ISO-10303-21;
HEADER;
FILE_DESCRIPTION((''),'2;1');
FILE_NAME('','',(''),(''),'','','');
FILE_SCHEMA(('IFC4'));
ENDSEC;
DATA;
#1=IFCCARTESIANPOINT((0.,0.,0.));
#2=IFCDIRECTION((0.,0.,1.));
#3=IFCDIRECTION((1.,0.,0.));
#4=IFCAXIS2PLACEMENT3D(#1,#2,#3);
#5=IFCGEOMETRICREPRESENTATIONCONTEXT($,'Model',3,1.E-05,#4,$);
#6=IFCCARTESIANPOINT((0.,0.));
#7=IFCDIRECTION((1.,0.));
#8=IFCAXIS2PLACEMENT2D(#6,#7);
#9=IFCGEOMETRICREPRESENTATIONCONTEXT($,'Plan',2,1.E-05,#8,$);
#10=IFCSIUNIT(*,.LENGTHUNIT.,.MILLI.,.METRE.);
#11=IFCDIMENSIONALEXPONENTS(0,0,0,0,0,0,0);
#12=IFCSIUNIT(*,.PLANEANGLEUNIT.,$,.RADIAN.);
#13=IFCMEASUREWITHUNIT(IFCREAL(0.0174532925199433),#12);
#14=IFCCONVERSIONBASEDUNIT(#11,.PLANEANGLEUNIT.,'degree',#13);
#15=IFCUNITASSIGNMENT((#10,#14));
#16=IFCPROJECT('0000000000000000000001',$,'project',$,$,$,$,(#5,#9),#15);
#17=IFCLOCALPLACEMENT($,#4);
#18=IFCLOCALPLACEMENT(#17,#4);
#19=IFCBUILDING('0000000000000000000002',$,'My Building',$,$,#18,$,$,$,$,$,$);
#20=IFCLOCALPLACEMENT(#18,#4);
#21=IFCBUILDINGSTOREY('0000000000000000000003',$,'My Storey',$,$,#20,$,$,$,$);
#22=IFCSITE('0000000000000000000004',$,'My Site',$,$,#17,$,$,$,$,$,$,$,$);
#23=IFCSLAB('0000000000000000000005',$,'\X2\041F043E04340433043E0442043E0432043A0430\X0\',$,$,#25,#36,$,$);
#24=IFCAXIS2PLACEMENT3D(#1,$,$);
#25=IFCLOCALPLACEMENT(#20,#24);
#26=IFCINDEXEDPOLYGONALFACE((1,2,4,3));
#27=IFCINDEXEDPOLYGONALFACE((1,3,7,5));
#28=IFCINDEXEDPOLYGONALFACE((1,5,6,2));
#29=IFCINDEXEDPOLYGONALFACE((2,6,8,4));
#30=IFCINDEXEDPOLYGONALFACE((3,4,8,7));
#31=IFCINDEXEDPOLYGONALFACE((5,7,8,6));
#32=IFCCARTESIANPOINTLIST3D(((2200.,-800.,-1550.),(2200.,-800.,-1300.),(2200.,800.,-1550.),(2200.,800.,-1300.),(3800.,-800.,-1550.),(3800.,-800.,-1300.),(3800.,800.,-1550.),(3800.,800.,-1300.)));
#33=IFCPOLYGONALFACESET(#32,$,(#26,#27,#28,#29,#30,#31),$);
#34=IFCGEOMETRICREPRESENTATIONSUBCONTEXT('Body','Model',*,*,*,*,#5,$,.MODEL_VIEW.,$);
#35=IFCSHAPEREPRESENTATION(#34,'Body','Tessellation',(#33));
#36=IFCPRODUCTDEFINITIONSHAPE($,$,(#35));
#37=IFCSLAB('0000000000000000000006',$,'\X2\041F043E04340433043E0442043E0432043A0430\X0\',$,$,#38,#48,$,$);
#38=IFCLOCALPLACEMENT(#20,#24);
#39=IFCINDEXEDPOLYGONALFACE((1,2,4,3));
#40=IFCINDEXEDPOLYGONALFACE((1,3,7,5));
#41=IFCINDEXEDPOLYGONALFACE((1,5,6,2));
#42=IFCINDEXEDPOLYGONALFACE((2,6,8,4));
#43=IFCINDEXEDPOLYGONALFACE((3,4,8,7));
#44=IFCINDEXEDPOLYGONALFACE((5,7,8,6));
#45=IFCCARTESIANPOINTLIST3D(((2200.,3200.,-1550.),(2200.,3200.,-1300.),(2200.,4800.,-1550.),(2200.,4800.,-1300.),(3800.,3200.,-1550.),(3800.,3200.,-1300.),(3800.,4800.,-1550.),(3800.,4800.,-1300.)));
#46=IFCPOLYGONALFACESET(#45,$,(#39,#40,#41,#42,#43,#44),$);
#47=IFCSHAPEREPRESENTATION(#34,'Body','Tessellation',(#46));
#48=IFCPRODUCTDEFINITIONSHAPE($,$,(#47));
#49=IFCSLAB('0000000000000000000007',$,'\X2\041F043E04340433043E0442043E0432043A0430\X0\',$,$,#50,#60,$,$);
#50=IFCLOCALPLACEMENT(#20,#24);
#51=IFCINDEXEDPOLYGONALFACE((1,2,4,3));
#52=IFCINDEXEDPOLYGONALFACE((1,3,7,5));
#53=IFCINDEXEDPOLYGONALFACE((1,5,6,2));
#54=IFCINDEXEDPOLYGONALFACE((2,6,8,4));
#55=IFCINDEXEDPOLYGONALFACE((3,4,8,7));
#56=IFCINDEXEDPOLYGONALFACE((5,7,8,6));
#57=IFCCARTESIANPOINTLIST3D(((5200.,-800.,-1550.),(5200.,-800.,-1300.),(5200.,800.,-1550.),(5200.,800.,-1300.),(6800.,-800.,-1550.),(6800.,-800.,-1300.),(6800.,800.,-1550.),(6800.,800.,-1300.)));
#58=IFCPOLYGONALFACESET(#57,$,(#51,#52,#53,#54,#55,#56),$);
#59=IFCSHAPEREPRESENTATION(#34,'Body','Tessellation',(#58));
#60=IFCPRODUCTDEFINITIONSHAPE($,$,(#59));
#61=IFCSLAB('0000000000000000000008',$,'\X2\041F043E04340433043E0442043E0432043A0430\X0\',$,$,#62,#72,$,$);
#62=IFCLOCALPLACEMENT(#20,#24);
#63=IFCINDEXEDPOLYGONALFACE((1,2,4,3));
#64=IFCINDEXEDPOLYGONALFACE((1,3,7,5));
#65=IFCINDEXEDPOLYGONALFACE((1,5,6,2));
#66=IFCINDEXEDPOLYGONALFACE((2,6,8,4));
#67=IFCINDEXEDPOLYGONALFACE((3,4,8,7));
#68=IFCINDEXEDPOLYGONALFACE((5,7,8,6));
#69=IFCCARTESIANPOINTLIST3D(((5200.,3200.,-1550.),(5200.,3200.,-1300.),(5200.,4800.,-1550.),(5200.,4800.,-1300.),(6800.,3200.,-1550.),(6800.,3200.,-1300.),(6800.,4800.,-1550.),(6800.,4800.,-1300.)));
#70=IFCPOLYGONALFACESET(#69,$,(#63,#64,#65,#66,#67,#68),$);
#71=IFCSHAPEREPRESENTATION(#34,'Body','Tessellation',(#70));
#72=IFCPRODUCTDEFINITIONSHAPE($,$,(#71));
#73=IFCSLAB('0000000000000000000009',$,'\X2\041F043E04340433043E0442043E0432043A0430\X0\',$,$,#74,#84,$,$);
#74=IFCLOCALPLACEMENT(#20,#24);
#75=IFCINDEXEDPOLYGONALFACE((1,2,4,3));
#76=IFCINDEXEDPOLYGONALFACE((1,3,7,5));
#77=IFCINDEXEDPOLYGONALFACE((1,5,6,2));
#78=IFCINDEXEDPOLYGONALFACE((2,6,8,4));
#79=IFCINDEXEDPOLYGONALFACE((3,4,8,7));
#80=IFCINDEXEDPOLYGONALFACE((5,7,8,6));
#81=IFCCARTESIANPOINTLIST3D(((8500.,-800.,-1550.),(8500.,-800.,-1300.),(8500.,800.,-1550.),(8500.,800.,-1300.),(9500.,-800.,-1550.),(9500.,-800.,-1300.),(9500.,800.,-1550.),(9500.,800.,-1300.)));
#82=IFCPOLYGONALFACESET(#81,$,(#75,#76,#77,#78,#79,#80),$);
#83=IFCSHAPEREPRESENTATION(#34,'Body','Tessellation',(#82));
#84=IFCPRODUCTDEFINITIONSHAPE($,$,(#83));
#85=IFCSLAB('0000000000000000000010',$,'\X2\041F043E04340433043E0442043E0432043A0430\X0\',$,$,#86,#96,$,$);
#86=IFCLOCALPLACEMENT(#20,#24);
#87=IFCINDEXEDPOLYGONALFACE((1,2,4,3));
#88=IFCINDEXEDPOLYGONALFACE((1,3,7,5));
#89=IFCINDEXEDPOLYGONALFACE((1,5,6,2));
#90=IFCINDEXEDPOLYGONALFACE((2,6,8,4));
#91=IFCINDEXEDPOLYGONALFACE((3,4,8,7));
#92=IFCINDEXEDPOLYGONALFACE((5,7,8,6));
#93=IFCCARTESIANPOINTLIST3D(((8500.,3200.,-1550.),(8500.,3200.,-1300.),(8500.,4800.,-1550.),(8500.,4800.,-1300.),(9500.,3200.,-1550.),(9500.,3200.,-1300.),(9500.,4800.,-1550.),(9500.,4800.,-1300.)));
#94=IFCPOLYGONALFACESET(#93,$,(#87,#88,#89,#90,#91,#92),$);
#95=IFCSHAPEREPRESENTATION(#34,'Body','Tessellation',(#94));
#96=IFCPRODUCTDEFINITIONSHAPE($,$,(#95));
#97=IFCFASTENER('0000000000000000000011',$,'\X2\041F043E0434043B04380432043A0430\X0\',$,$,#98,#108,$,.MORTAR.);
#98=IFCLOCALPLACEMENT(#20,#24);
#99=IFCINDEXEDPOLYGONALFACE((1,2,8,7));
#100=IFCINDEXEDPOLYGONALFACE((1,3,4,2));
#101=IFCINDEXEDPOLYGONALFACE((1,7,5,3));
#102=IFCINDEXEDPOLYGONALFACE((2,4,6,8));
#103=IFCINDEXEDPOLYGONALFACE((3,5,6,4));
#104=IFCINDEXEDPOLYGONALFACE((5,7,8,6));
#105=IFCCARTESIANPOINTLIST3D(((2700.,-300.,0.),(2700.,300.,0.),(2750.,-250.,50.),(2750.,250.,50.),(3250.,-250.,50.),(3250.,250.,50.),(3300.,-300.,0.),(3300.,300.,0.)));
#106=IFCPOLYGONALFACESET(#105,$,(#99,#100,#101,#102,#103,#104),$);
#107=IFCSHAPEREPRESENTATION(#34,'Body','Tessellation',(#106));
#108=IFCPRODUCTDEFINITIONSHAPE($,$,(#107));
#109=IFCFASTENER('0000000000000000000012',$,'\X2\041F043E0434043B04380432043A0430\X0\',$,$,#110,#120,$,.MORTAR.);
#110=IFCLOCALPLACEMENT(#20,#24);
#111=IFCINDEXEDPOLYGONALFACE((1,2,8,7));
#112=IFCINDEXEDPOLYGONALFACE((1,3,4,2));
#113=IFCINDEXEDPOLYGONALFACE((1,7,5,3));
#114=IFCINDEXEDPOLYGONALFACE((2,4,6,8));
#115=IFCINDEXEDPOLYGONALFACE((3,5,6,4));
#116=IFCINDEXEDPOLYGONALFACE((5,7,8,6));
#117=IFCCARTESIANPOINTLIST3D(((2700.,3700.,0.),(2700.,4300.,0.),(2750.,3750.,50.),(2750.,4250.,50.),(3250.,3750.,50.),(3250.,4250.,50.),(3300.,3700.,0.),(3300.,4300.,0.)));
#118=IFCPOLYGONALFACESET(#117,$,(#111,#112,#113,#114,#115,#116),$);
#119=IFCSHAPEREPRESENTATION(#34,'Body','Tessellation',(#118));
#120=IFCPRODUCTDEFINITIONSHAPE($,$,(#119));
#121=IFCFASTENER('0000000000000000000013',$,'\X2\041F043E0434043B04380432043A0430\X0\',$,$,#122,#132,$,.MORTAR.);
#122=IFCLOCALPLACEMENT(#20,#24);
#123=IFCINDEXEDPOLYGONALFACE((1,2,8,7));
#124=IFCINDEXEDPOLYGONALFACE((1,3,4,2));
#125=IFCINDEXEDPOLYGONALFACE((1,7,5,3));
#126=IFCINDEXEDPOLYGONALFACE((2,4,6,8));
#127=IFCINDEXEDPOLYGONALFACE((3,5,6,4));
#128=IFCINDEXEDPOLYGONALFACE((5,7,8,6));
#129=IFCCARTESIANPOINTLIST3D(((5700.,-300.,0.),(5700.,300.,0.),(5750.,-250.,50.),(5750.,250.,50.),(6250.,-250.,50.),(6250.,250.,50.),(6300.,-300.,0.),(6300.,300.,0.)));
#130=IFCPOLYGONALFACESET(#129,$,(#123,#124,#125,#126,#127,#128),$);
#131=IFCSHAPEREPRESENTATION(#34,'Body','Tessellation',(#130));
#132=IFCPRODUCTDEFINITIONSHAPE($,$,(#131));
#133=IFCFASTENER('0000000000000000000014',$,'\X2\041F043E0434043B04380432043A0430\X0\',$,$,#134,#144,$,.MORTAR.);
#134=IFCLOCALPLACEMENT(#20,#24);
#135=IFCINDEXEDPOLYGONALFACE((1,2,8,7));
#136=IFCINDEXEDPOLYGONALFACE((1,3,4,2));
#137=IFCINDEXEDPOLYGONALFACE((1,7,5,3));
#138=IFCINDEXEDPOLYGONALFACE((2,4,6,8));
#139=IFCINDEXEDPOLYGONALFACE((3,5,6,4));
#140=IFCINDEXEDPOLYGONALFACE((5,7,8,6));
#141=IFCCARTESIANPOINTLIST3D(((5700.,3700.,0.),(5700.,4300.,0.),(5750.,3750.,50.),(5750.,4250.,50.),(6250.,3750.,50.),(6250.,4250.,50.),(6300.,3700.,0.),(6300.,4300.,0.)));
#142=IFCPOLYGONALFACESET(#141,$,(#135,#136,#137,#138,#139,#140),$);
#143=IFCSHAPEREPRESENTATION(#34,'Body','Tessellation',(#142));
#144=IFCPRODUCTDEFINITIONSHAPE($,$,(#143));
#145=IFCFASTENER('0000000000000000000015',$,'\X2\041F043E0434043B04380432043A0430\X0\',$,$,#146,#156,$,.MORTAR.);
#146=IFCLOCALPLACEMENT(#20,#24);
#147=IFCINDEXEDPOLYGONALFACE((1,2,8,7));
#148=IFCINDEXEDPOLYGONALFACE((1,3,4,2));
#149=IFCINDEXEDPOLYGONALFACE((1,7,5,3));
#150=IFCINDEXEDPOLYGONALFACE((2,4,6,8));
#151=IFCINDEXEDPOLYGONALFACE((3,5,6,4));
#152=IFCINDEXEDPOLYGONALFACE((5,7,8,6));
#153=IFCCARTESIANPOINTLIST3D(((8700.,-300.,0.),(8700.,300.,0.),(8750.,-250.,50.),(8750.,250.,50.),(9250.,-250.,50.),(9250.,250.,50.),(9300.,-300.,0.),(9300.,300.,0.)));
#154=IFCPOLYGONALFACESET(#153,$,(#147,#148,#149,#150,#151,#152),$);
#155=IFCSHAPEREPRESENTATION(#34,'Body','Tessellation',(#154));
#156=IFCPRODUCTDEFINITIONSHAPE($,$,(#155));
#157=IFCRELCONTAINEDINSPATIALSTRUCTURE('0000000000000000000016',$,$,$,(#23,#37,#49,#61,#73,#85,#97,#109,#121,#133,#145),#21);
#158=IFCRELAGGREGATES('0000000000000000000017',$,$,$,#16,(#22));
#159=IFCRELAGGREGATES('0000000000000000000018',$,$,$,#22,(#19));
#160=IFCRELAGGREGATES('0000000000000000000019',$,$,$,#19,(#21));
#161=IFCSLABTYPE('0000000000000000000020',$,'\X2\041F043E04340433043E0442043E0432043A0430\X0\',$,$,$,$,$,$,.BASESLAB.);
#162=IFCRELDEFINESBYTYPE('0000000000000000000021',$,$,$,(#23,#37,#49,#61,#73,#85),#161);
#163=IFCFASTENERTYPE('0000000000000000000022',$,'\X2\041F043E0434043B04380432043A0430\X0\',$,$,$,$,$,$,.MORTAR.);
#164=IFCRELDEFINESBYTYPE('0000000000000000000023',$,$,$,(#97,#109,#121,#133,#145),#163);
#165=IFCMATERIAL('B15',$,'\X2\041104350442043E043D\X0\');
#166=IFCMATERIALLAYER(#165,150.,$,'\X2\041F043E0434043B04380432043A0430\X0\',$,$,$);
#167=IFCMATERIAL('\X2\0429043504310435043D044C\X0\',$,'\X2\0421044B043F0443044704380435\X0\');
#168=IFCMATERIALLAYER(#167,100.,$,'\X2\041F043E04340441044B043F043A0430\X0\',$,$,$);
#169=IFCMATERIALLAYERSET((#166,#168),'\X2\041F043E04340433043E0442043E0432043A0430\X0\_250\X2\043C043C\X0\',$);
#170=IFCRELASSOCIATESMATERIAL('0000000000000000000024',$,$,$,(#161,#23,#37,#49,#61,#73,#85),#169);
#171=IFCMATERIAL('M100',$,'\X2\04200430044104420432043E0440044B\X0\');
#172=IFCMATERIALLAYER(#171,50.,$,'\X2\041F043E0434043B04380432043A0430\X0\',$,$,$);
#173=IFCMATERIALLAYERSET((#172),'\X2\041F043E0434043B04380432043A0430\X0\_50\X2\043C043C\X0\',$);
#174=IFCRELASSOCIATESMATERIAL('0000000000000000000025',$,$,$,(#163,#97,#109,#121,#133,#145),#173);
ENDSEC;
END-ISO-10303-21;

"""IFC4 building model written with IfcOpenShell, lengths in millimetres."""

from ifc_helpers import new_model, entity, si_unit, converted_unit, frame, origin_with_axes, origin_2d_with_axis, place, context, subcontext, project, spatial, line, indexed_curve, outline, extrude, clip, halfspace, material, layer, layer_set, layer_usage, type_object, element, save


model = new_model("IFC4")

# Units and contexts
model_context = context("Model", 3, precision=1e-05, world=origin_with_axes())
plan_context = context("Plan", 2, precision=1e-05, world=origin_2d_with_axis())
body_context = subcontext(model_context, "Body", "Model", "MODEL_VIEW")
ifc_project = project(units=[si_unit("LENGTHUNIT", "METRE", prefix="MILLI"), converted_unit("PLANEANGLEUNIT", "degree", entity("IfcReal", 0.0174532925199433), si_unit("PLANEANGLEUNIT", "RADIAN"), dimensions=[0, 0, 0, 0, 0, 0, 0])], contexts=[model_context, plan_context])

# Site, building, storey
site_placement = place(None, origin_with_axes())
site = spatial("IfcSite", under=ifc_project, at=site_placement, Name="My Site")
building_placement = place(site_placement, origin_with_axes())
building = spatial("IfcBuilding", under=site, at=building_placement, Name="My Building")
storey_placement = place(building_placement, origin_with_axes())
storey = spatial("IfcBuildingStorey", under=building, at=storey_placement, Name="My Storey")

# Slabs
ifc_material_1 = material(Name="B15", Category="Бетон")
ifc_layer_1 = layer(ifc_material_1, 150.0, Name="Подливка")
ifc_material_2 = material(Name="Щебень", Category="Сыпучие")
ifc_layer_2 = layer(ifc_material_2, 100.0, Name="Подсыпка")
ifc_layer_set_1 = layer_set([ifc_layer_1, ifc_layer_2], Name="Подготовка_250мм")
ifc_layer_usage_1 = layer_usage(ifc_layer_set_1, "AXIS3", "NEGATIVE", 0.0)
slab_type = type_object("IfcSlabType", Name="Подготовка", PredefinedType="BASESLAB", material=ifc_layer_set_1)
slab_1_placement = place(storey_placement, frame((3000.0, 0.0, -1550.0), z_axis=(0.0, 0.0, 1.0), x_axis=(1.0, 0.0, 0.0)))
element("IfcSlab", 1, at=slab_1_placement, inside=storey, type_object=slab_type, material=ifc_layer_usage_1, Name="Подготовка", context=body_context, shape_type="SweptSolid", body=[
    extrude(outline(indexed_curve([(800.0, 800.0), (800.0, -800.0), (-800.0, -800.0), (-800.0, 800.0)], segments=[line(3, 2), line(2, 1), line(1, 4), line(4, 3)], self_intersect=False)), None, (0.0, 0.0, 1.0), 250.0),
])
slab_2_placement = place(storey_placement, frame((3000.0, 4000.0, -1550.0), z_axis=(0.0, 0.0, 1.0), x_axis=(1.0, 0.0, 0.0)))
element("IfcSlab", 2, at=slab_2_placement, inside=storey, type_object=slab_type, material=ifc_layer_usage_1, Name="Подготовка", context=body_context, shape_type="SweptSolid", body=[
    extrude(outline(indexed_curve([(-800.0, -800.0), (800.0, -800.0), (800.0, 800.0), (-800.0, 800.0)], segments=[line(3, 2), line(2, 1), line(1, 4), line(4, 3)], self_intersect=False)), None, (0.0, 0.0, 1.0), 250.0),
])
for number, where, z_axis, x_axis, name in (
    (3, (6000.0, 0.0, -1550.0), (0.0, 0.0, 1.0), (1.0, 0.0, 0.0), "Подготовка"),
    (4, (6000.0, 4000.0, -1550.0), (0.0, 0.0, 1.0), (1.0, 0.0, 0.0), "Подготовка"),
):
    element("IfcSlab", number, at=place(storey_placement, frame(where, z_axis=z_axis, x_axis=x_axis)), inside=storey, type_object=slab_type, material=ifc_layer_usage_1, Name=name, context=body_context, shape_type="SweptSolid", body=[
        extrude(outline(indexed_curve([(800.0, 800.0), (800.0, -800.0), (-800.0, -800.0), (-800.0, 800.0)], segments=[line(3, 2), line(2, 1), line(1, 4), line(4, 3)], self_intersect=False)), None, (0.0, 0.0, 1.0), 250.0),
    ])
slab_3_placement = place(storey_placement, frame((9000.0, 0.0, -1550.0), z_axis=(0.0, 0.0, 1.0), x_axis=(1.0, 0.0, 0.0)))
element("IfcSlab", 5, at=slab_3_placement, inside=storey, type_object=slab_type, material=ifc_layer_usage_1, Name="Подготовка", context=body_context, shape_type="SweptSolid", body=[
    extrude(outline(indexed_curve([(500.0, 800.0), (500.0, -800.0), (-500.0, -800.0), (-500.0, 800.0)], segments=[line(3, 2), line(2, 1), line(1, 4), line(4, 3)], self_intersect=False)), None, (0.0, 0.0, 1.0), 250.0),
])
slab_4_placement = place(storey_placement, frame((9000.0, 4000.0, -1550.0), z_axis=(0.0, 0.0, 1.0), x_axis=(1.0, 0.0, 0.0)))
element("IfcSlab", 6, at=slab_4_placement, inside=storey, type_object=slab_type, material=ifc_layer_usage_1, Name="Подготовка", context=body_context, shape_type="SweptSolid", body=[
    extrude(outline(indexed_curve([(-500.0, -800.0), (500.0, -800.0), (500.0, 800.0), (-500.0, 800.0)], segments=[line(3, 2), line(2, 1), line(1, 4), line(4, 3)], self_intersect=False)), None, (0.0, 0.0, 1.0), 250.0),
])

# Fasteners
ifc_material_3 = material(Name="M100", Category="Растворы")
ifc_layer_3 = layer(ifc_material_3, 50.0, Name="Подливка")
ifc_layer_set_2 = layer_set([ifc_layer_3], Name="Подливка_50мм")
ifc_layer_usage_2 = layer_usage(ifc_layer_set_2, "AXIS3", "POSITIVE", 0.0)
fastener_type = type_object("IfcFastenerType", Name="Подливка", PredefinedType="MORTAR", material=ifc_layer_set_2)
fastener_1_placement = place(storey_placement, frame((3000.0, 0.0, 0.0), z_axis=(0.0, 0.0, 1.0), x_axis=(1.0, 0.0, 0.0)))
element("IfcFastener", 7, at=fastener_1_placement, inside=storey, type_object=fastener_type, material=ifc_layer_usage_2, Name="Подливка", PredefinedType="MORTAR", context=body_context, shape_type="Clipping", body=[
    clip(clip(clip(clip(extrude(outline(indexed_curve([(-300.0, -300.0), (300.0, -300.0), (300.0, 300.0), (-300.0, 300.0)], segments=[line(3, 2), line(2, 1), line(1, 4), line(4, 3)], self_intersect=False)), None, (0.0, 0.0, 1.0), 50.0), halfspace(frame((-53.6, 200.0, 353.6), z_axis=(0.707107, 0.0, 0.707107), x_axis=(0.707107, 0.0, -0.707107)), False)), halfspace(frame((-200.0, -53.6, 353.6), z_axis=(0.0, 0.707107, 0.707107), x_axis=(0.0, 0.707107, -0.707107)), False)), halfspace(frame((200.0, 53.6, 353.6), z_axis=(0.0, -0.707107, 0.707107), x_axis=(0.0, -0.707107, -0.707107)), False)), halfspace(frame((53.6, 200.0, 353.6), z_axis=(-0.707107, 0.0, 0.707107), x_axis=(-0.707107, 0.0, -0.707107)), False)),
])
ifc_layer_usage_3 = layer_usage(ifc_layer_set_2, "AXIS3", "POSITIVE", 0.0)
fastener_2_placement = place(storey_placement, frame((3000.0, 4000.0, 0.0), z_axis=(0.0, 0.0, 1.0), x_axis=(1.0, 0.0, 0.0)))
element("IfcFastener", 8, at=fastener_2_placement, inside=storey, type_object=fastener_type, material=ifc_layer_usage_3, Name="Подливка", PredefinedType="MORTAR", context=body_context, shape_type="Clipping", body=[
    clip(clip(clip(clip(extrude(outline(indexed_curve([(-300.0, -300.0), (300.0, -300.0), (300.0, 300.0), (-300.0, 300.0)], segments=[line(3, 2), line(2, 1), line(1, 4), line(4, 3)], self_intersect=False)), None, (0.0, 0.0, 1.0), 50.0), halfspace(frame((-53.6, 200.0, 353.6), z_axis=(0.707107, 0.0, 0.707107), x_axis=(0.707107, 0.0, -0.707107)), False)), halfspace(frame((-200.0, -53.6, 353.6), z_axis=(0.0, 0.707107, 0.707107), x_axis=(0.0, 0.707107, -0.707107)), False)), halfspace(frame((200.0, 53.6, 353.6), z_axis=(0.0, -0.707107, 0.707107), x_axis=(0.0, -0.707107, -0.707107)), False)), halfspace(frame((53.6, 200.0, 353.6), z_axis=(-0.707107, 0.0, 0.707107), x_axis=(-0.707107, 0.0, -0.707107)), False)),
])
ifc_layer_usage_4 = layer_usage(ifc_layer_set_2, "AXIS3", "POSITIVE", 0.0)
fastener_3_placement = place(storey_placement, frame((6000.0, 0.0, 0.0), z_axis=(0.0, 0.0, 1.0), x_axis=(1.0, 0.0, 0.0)))
element("IfcFastener", 9, at=fastener_3_placement, inside=storey, type_object=fastener_type, material=ifc_layer_usage_4, Name="Подливка", PredefinedType="MORTAR", context=body_context, shape_type="Clipping", body=[
    clip(clip(clip(clip(extrude(outline(indexed_curve([(-300.0, -300.0), (300.0, -300.0), (300.0, 300.0), (-300.0, 300.0)], segments=[line(3, 2), line(2, 1), line(1, 4), line(4, 3)], self_intersect=False)), None, (0.0, 0.0, 1.0), 50.0), halfspace(frame((-53.6, 200.0, 353.6), z_axis=(0.707107, 0.0, 0.707107), x_axis=(0.707107, 0.0, -0.707107)), False)), halfspace(frame((-200.0, -53.6, 353.6), z_axis=(0.0, 0.707107, 0.707107), x_axis=(0.0, 0.707107, -0.707107)), False)), halfspace(frame((200.0, 53.6, 353.6), z_axis=(0.0, -0.707107, 0.707107), x_axis=(0.0, -0.707107, -0.707107)), False)), halfspace(frame((53.6, 200.0, 353.6), z_axis=(-0.707107, 0.0, 0.707107), x_axis=(-0.707107, 0.0, -0.707107)), False)),
])
ifc_layer_usage_5 = layer_usage(ifc_layer_set_2, "AXIS3", "POSITIVE", 0.0)
fastener_4_placement = place(storey_placement, frame((6000.0, 4000.0, 0.0), z_axis=(0.0, 0.0, 1.0), x_axis=(1.0, 0.0, 0.0)))
element("IfcFastener", 10, at=fastener_4_placement, inside=storey, type_object=fastener_type, material=ifc_layer_usage_5, Name="Подливка", PredefinedType="MORTAR", context=body_context, shape_type="Clipping", body=[
    clip(clip(clip(clip(extrude(outline(indexed_curve([(-300.0, -300.0), (300.0, -300.0), (300.0, 300.0), (-300.0, 300.0)], segments=[line(3, 2), line(2, 1), line(1, 4), line(4, 3)], self_intersect=False)), None, (0.0, 0.0, 1.0), 50.0), halfspace(frame((-53.6, 200.0, 353.6), z_axis=(0.707107, 0.0, 0.707107), x_axis=(0.707107, 0.0, -0.707107)), False)), halfspace(frame((-200.0, -53.6, 353.6), z_axis=(0.0, 0.707107, 0.707107), x_axis=(0.0, 0.707107, -0.707107)), False)), halfspace(frame((200.0, 53.6, 353.6), z_axis=(0.0, -0.707107, 0.707107), x_axis=(0.0, -0.707107, -0.707107)), False)), halfspace(frame((53.6, 200.0, 353.6), z_axis=(-0.707107, 0.0, 0.707107), x_axis=(-0.707107, 0.0, -0.707107)), False)),
])
ifc_layer_usage_6 = layer_usage(ifc_layer_set_2, "AXIS3", "POSITIVE", 0.0)
fastener_5_placement = place(storey_placement, frame((9000.0, 0.0, 0.0), z_axis=(0.0, 0.0, 1.0), x_axis=(1.0, 0.0, 0.0)))
element("IfcFastener", 11, at=fastener_5_placement, inside=storey, type_object=fastener_type, material=ifc_layer_usage_6, Name="Подливка", PredefinedType="MORTAR", context=body_context, shape_type="Clipping", body=[
    clip(clip(clip(clip(extrude(outline(indexed_curve([(-300.0, -300.0), (300.0, -300.0), (300.0, 300.0), (-300.0, 300.0)], segments=[line(3, 2), line(2, 1), line(1, 4), line(4, 3)], self_intersect=False)), None, (0.0, 0.0, 1.0), 50.0), halfspace(frame((-53.6, 200.0, 353.6), z_axis=(0.707107, 0.0, 0.707107), x_axis=(0.707107, 0.0, -0.707107)), False)), halfspace(frame((-200.0, -53.6, 353.6), z_axis=(0.0, 0.707107, 0.707107), x_axis=(0.0, 0.707107, -0.707107)), False)), halfspace(frame((200.0, 53.6, 353.6), z_axis=(0.0, -0.707107, 0.707107), x_axis=(0.0, -0.707107, -0.707107)), False)), halfspace(frame((53.6, 200.0, 353.6), z_axis=(-0.707107, 0.0, 0.707107), x_axis=(-0.707107, 0.0, -0.707107)), False)),
])

save(model, "model.ifc")
